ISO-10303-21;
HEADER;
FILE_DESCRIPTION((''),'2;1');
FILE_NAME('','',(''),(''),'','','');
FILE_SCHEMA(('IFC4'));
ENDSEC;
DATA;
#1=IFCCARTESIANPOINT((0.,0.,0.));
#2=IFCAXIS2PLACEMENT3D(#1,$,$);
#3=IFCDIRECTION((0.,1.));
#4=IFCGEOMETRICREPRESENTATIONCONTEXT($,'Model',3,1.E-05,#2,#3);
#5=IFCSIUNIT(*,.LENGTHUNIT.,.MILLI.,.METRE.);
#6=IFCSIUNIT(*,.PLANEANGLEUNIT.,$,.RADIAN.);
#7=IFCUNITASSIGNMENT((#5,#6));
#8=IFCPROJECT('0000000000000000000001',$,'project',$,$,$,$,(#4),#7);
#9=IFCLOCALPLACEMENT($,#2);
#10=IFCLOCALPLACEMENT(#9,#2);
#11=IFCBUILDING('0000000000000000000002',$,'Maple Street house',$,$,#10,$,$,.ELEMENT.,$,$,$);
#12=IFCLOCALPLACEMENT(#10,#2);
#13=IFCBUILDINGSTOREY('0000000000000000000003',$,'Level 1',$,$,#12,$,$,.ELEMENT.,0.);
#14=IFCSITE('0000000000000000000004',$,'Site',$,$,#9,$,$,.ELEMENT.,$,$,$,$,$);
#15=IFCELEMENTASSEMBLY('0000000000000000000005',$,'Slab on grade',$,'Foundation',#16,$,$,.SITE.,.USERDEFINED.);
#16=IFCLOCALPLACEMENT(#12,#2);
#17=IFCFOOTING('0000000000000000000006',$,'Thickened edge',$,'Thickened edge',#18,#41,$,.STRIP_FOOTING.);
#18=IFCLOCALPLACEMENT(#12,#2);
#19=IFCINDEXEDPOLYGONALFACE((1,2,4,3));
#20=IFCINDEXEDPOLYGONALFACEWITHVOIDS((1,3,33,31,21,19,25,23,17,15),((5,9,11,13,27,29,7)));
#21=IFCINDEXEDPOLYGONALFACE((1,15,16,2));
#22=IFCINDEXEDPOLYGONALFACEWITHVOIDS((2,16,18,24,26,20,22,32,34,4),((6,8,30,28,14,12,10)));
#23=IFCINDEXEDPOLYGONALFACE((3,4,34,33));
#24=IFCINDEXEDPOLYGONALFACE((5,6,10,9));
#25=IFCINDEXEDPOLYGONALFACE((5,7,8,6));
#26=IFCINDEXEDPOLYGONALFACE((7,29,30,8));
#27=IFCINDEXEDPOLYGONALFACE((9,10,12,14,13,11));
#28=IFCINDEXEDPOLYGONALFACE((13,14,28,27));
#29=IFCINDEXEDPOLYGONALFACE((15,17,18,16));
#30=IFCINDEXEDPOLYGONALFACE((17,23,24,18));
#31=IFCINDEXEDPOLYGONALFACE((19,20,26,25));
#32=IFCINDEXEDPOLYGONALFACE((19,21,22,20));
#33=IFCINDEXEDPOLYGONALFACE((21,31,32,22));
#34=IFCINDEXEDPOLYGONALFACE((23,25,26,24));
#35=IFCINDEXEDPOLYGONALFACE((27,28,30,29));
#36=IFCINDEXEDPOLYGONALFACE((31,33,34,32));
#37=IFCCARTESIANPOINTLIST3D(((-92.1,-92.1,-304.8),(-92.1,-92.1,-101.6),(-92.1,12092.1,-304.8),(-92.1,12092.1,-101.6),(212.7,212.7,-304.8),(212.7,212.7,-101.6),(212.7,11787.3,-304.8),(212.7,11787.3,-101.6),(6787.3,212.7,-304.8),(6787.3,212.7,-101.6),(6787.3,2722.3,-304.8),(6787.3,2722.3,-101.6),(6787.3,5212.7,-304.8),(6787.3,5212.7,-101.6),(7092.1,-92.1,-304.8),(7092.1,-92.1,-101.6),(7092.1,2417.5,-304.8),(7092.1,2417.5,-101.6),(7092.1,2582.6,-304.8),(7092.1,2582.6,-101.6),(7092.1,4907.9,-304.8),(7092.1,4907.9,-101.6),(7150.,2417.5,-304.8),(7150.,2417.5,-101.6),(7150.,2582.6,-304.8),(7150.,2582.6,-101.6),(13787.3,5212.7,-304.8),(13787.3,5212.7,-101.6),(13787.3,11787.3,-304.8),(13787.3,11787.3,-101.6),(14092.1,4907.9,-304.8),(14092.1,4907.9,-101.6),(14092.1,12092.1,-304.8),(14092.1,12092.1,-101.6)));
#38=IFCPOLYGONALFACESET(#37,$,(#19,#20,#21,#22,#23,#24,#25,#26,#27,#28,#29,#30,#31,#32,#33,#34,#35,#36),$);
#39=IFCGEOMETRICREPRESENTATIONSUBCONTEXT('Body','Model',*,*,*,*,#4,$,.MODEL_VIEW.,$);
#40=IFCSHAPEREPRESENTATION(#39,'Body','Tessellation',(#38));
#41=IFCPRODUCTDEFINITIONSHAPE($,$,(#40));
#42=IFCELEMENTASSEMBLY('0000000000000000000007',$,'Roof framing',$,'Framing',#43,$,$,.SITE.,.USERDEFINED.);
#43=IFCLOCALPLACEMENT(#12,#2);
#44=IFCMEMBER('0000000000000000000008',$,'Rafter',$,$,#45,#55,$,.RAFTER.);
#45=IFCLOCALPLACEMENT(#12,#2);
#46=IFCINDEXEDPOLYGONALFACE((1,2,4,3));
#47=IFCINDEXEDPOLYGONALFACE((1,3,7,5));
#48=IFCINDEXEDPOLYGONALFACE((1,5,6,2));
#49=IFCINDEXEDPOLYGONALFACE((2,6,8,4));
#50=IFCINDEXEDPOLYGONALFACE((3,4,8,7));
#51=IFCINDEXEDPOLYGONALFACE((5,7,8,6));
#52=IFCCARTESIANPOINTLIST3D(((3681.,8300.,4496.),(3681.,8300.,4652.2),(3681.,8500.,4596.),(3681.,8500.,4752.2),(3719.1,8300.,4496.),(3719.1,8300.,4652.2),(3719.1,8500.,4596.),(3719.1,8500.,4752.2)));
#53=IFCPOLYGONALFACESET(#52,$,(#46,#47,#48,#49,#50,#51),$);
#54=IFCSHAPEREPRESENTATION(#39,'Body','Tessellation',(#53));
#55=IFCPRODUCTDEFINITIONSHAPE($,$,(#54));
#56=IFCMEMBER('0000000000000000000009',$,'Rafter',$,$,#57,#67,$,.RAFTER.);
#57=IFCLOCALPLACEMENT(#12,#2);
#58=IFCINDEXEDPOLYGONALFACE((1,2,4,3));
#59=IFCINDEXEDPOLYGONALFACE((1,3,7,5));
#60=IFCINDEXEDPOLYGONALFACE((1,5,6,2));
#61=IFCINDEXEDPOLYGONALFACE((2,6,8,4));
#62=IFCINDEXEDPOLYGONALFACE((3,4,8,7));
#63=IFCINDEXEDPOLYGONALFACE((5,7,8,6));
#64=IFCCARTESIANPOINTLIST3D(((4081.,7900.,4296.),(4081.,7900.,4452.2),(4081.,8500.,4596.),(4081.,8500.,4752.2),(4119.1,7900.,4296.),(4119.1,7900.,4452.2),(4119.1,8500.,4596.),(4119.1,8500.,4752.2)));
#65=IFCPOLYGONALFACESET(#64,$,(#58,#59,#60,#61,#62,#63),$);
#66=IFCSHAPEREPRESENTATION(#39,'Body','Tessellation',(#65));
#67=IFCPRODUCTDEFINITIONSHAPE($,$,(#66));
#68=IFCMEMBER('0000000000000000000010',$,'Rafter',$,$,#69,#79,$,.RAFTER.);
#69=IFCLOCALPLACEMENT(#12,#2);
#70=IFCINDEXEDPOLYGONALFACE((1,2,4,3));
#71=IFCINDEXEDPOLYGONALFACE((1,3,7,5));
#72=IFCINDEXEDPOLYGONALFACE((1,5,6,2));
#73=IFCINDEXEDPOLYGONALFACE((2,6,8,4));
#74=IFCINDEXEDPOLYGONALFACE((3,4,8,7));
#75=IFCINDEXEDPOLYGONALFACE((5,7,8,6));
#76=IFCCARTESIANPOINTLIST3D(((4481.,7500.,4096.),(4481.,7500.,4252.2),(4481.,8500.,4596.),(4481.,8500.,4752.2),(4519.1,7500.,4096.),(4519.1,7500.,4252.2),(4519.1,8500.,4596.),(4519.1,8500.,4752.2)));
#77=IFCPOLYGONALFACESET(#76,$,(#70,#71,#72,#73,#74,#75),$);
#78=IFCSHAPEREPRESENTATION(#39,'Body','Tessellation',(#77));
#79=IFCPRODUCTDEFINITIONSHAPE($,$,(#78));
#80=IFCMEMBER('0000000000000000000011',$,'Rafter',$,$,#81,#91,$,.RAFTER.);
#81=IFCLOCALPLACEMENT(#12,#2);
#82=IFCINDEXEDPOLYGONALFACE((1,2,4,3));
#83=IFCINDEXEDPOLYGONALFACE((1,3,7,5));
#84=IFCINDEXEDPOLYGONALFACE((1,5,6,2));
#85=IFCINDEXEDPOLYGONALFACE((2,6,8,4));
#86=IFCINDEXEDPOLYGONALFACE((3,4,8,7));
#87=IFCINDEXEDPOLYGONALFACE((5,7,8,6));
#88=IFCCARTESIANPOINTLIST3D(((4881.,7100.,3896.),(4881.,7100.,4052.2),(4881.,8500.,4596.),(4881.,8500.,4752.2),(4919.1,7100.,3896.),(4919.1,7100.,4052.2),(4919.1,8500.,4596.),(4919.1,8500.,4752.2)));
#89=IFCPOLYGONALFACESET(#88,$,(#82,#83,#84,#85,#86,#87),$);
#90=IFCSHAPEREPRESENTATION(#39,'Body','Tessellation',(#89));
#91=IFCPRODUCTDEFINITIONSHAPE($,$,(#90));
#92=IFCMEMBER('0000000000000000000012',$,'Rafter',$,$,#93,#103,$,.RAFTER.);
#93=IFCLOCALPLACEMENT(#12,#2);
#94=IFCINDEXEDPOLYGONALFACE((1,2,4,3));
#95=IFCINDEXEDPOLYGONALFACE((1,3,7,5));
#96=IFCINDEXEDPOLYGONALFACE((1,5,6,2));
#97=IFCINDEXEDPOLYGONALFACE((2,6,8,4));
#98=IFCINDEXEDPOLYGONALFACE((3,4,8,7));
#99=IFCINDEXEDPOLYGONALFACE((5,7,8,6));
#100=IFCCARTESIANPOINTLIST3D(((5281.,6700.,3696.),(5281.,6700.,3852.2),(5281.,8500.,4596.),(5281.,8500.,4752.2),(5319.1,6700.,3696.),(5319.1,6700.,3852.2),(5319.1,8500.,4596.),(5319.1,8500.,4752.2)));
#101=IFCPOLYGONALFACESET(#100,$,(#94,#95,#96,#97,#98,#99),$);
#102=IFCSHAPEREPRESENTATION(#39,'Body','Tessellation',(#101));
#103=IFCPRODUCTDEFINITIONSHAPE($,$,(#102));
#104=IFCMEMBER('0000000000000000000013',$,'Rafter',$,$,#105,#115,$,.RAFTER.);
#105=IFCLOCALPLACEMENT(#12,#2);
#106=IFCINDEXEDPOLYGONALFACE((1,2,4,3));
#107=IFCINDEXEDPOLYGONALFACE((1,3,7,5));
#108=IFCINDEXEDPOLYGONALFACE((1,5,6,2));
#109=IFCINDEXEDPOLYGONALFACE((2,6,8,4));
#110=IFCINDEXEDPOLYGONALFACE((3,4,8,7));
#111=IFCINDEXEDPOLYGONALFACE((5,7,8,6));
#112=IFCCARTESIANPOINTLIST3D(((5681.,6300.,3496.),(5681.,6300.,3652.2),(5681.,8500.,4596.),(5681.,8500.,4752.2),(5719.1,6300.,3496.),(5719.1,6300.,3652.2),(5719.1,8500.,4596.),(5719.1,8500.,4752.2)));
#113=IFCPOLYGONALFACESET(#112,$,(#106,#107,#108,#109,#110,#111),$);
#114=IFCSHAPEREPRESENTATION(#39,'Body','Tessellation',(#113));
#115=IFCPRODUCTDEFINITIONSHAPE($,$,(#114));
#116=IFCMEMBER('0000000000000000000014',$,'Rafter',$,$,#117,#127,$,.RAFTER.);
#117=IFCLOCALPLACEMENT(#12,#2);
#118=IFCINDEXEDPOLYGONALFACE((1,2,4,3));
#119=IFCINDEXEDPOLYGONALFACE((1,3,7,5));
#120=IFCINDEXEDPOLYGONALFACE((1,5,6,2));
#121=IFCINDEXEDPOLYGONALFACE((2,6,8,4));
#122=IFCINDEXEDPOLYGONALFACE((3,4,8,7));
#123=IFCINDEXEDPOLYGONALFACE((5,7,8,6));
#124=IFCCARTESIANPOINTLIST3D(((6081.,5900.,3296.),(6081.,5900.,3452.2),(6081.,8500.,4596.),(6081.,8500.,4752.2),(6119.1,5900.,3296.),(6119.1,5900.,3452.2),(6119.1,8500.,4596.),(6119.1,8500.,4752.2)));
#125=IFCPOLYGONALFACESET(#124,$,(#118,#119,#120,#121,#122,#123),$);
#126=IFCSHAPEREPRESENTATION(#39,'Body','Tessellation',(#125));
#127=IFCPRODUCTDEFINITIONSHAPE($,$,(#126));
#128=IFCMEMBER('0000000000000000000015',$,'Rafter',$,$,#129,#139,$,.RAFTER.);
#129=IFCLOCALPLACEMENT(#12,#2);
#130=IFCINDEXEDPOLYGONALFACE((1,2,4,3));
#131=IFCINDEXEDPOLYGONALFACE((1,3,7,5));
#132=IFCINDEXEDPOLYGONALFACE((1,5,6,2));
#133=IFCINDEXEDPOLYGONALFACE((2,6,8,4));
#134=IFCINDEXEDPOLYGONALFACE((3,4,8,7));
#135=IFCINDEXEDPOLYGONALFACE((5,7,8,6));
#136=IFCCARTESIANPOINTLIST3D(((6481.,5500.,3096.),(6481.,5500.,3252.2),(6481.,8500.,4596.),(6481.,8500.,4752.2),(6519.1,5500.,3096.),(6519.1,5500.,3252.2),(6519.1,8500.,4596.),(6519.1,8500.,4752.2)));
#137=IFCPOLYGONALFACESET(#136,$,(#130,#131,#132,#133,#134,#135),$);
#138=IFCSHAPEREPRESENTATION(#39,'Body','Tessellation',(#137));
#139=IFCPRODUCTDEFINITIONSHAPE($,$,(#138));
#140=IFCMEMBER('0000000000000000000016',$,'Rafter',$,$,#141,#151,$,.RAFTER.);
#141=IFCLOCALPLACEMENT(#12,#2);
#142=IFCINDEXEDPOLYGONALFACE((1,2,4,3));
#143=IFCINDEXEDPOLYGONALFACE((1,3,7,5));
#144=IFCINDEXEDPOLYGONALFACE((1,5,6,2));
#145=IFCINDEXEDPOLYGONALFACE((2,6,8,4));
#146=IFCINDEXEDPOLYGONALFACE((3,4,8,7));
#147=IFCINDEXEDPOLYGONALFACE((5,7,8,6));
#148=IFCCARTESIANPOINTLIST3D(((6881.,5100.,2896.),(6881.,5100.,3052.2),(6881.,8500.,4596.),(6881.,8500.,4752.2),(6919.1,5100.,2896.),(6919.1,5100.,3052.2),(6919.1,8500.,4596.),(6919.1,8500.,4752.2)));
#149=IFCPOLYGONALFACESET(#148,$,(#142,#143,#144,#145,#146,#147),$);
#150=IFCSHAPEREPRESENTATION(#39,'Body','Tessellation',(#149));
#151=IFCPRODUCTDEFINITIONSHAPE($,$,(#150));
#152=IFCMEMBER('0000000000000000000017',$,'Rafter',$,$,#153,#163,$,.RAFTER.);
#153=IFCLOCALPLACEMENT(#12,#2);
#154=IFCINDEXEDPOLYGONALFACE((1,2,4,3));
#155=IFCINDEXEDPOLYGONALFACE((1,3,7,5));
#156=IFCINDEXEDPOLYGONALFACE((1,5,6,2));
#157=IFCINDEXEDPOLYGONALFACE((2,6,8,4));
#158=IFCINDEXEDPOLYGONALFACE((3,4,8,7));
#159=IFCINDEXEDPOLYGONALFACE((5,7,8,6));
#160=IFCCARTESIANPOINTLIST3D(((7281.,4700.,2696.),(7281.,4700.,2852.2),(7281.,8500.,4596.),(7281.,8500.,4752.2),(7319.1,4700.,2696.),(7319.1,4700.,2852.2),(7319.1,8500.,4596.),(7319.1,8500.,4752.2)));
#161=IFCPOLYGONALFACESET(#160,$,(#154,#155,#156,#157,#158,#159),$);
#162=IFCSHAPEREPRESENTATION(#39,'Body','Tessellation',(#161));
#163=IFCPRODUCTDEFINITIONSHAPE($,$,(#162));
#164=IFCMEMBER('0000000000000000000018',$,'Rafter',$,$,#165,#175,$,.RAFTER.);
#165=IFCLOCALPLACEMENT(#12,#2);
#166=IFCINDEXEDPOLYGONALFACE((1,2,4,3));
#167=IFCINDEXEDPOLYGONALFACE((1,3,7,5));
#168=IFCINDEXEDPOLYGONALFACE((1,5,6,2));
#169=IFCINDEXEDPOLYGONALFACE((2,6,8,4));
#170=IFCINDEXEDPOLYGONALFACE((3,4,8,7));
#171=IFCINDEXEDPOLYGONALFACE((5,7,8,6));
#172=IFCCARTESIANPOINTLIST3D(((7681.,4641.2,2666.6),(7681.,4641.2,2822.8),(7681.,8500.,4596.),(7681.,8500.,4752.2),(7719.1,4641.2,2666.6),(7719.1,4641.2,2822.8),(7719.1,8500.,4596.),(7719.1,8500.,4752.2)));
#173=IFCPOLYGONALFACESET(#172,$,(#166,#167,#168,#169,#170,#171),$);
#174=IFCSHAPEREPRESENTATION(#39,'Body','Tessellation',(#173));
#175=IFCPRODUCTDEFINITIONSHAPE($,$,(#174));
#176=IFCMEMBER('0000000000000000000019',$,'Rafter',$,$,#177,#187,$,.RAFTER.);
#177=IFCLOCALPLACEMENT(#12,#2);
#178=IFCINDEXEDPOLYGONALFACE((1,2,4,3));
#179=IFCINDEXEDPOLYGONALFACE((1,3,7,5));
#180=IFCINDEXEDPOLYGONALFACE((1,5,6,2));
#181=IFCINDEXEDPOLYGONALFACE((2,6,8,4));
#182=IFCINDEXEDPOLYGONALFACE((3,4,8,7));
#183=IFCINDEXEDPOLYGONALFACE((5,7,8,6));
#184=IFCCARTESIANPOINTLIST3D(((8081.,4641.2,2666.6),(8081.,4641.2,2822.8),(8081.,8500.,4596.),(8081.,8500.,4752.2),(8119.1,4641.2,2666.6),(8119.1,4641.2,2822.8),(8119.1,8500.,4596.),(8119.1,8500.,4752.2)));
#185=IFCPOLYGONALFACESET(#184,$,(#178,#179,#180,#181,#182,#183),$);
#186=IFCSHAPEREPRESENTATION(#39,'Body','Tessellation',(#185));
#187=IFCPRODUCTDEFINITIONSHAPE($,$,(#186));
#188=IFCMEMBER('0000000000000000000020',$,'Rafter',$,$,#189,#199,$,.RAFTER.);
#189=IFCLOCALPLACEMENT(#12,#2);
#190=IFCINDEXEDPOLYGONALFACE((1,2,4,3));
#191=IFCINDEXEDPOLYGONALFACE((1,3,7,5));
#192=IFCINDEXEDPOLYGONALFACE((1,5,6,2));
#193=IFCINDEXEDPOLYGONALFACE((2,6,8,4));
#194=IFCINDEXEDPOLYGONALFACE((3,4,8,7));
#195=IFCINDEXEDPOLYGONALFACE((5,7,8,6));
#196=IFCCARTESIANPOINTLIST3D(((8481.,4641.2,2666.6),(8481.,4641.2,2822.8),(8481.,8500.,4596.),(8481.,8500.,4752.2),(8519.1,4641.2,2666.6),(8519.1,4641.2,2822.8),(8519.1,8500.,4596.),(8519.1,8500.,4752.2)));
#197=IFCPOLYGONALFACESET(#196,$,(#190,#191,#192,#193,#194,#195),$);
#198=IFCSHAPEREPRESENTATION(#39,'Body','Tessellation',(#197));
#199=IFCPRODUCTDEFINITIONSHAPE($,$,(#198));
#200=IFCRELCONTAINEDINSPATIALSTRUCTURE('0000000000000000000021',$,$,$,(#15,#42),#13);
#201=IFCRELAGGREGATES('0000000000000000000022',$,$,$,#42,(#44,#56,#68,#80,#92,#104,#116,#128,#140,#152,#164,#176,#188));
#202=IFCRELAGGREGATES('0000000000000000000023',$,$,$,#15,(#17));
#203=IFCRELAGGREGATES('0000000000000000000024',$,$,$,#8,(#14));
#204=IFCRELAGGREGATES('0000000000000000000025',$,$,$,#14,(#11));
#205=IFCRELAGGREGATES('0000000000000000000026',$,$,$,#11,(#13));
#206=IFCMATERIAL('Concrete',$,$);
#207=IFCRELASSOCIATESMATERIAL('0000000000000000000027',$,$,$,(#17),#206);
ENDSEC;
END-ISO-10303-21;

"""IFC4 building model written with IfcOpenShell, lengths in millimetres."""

from ifc_helpers import new_model, si_unit, direction, frame, origin, origin_with_axes, place, context, subcontext, project, spatial, polyline, outline, extrude, material, element, aggregate, save


model = new_model("IFC4")

# Units and contexts
model_context = context("Model", 3, precision=1e-05, world=origin(), true_north=direction((0.0, 1.0)))
body_context = subcontext(model_context, "Body", "Model", "MODEL_VIEW")
ifc_project = project(units=[si_unit("LENGTHUNIT", "METRE", prefix="MILLI"), si_unit("PLANEANGLEUNIT", "RADIAN")], contexts=[model_context])

# Site, building, storey
site_placement = place(None, origin())
site = spatial("IfcSite", under=ifc_project, at=site_placement, Name="Site", CompositionType="ELEMENT")
building_placement = place(site_placement, origin())
building = spatial("IfcBuilding", under=site, at=building_placement, Name="Maple Street house", CompositionType="ELEMENT")
storey_placement = place(building_placement, origin())
storey = spatial("IfcBuildingStorey", under=building, at=storey_placement, Name="Level 1", CompositionType="ELEMENT", Elevation=0.0)

# Element assembly, footing
assembly_1_placement = place(storey_placement, origin_with_axes())
assembly_1 = element("IfcElementAssembly", 1, at=assembly_1_placement, inside=storey, Name="Slab on grade", ObjectType="Foundation", AssemblyPlace="SITE", PredefinedType="USERDEFINED")
ifc_material = material(Name="Concrete")
footing_placement = place(storey_placement, origin_with_axes())
footing = element("IfcFooting", 2, at=footing_placement, material=ifc_material, Name="Thickened edge", ObjectType="Thickened edge", PredefinedType="STRIP_FOOTING", context=body_context, shape_type="SweptSolid", body=[
    extrude(outline(polyline([(7092.1, 2417.5), (7150.0, 2417.5), (7150.0, 2582.6), (7092.1, 2582.6), (7092.1, 4907.9), (14092.1, 4907.9), (14092.1, 12092.1), (-92.1, 12092.1), (-92.1, -92.1), (7092.1, -92.1), (7092.1, 2417.5)]), holes=[polyline([(6787.3, 2722.3), (6845.2, 2722.3), (6845.2, 2277.8), (6787.3, 2277.8), (6787.3, 5212.7), (13787.3, 5212.7), (13787.3, 11787.3), (212.7, 11787.3), (212.7, 212.7), (6787.3, 212.7), (6787.3, 2722.3)])]), frame((0.0, 0.0, -304.8)), (0.0, 0.0, 1.0), 203.2),
])

# Element assembly, members
assembly_2_placement = place(storey_placement, origin_with_axes())
assembly_2 = element("IfcElementAssembly", 3, at=assembly_2_placement, inside=storey, Name="Roof framing", ObjectType="Framing", AssemblyPlace="SITE", PredefinedType="USERDEFINED")
member_1_placement = place(storey_placement, origin_with_axes())
member_1 = element("IfcMember", 4, at=member_1_placement, Name="Rafter", PredefinedType="RAFTER", context=body_context, shape_type="SweptSolid", body=[
    extrude(outline(polyline([(0.0, 0.0), (38.1, 0.0), (38.1, 156.2), (0.0, 156.2), (0.0, 0.0)])), frame((3719.1, 8300.0, 4496.0), z_axis=(0.0, 1.0, 0.0), x_axis=(-1.0, 0.0, 0.0)), (0.0, 0.447214, 0.894427), 223.6),
])
member_2_placement = place(storey_placement, origin_with_axes())
member_2 = element("IfcMember", 5, at=member_2_placement, Name="Rafter", PredefinedType="RAFTER", context=body_context, shape_type="SweptSolid", body=[
    extrude(outline(polyline([(0.0, 0.0), (38.1, 0.0), (38.1, 156.2), (0.0, 156.2), (0.0, 0.0)])), frame((4119.1, 7900.0, 4296.0), z_axis=(0.0, 1.0, 0.0), x_axis=(-1.0, 0.0, 0.0)), (0.0, 0.447214, 0.894427), 670.8),
])
member_3_placement = place(storey_placement, origin_with_axes())
member_3 = element("IfcMember", 6, at=member_3_placement, Name="Rafter", PredefinedType="RAFTER", context=body_context, shape_type="SweptSolid", body=[
    extrude(outline(polyline([(0.0, 0.0), (38.1, 0.0), (38.1, 156.2), (0.0, 156.2), (0.0, 0.0)])), frame((4519.1, 7500.0, 4096.0), z_axis=(0.0, 1.0, 0.0), x_axis=(-1.0, 0.0, 0.0)), (0.0, 0.447214, 0.894427), 1118.0),
])
member_4_placement = place(storey_placement, origin_with_axes())
member_4 = element("IfcMember", 7, at=member_4_placement, Name="Rafter", PredefinedType="RAFTER", context=body_context, shape_type="SweptSolid", body=[
    extrude(outline(polyline([(0.0, 0.0), (38.1, 0.0), (38.1, 156.2), (0.0, 156.2), (0.0, 0.0)])), frame((4919.1, 7100.0, 3896.0), z_axis=(0.0, 1.0, 0.0), x_axis=(-1.0, 0.0, 0.0)), (0.0, 0.447214, 0.894427), 1565.2),
])
member_5_placement = place(storey_placement, origin_with_axes())
member_5 = element("IfcMember", 8, at=member_5_placement, Name="Rafter", PredefinedType="RAFTER", context=body_context, shape_type="SweptSolid", body=[
    extrude(outline(polyline([(0.0, 0.0), (38.1, 0.0), (38.1, 156.2), (0.0, 156.2), (0.0, 0.0)])), frame((5319.1, 6700.0, 3696.0), z_axis=(0.0, 1.0, 0.0), x_axis=(-1.0, 0.0, 0.0)), (0.0, 0.447214, 0.894427), 2012.5),
])
member_6_placement = place(storey_placement, origin_with_axes())
member_6 = element("IfcMember", 9, at=member_6_placement, Name="Rafter", PredefinedType="RAFTER", context=body_context, shape_type="SweptSolid", body=[
    extrude(outline(polyline([(0.0, 0.0), (38.1, 0.0), (38.1, 156.2), (0.0, 156.2), (0.0, 0.0)])), frame((5719.1, 6300.0, 3496.0), z_axis=(0.0, 1.0, 0.0), x_axis=(-1.0, 0.0, 0.0)), (0.0, 0.447214, 0.894427), 2459.7),
])
member_7_placement = place(storey_placement, origin_with_axes())
member_7 = element("IfcMember", 10, at=member_7_placement, Name="Rafter", PredefinedType="RAFTER", context=body_context, shape_type="SweptSolid", body=[
    extrude(outline(polyline([(0.0, 0.0), (38.1, 0.0), (38.1, 156.2), (0.0, 156.2), (0.0, 0.0)])), frame((6119.1, 5900.0, 3296.0), z_axis=(0.0, 1.0, 0.0), x_axis=(-1.0, 0.0, 0.0)), (0.0, 0.447214, 0.894427), 2906.9),
])
member_8_placement = place(storey_placement, origin_with_axes())
member_8 = element("IfcMember", 11, at=member_8_placement, Name="Rafter", PredefinedType="RAFTER", context=body_context, shape_type="SweptSolid", body=[
    extrude(outline(polyline([(0.0, 0.0), (38.1, 0.0), (38.1, 156.2), (0.0, 156.2), (0.0, 0.0)])), frame((6519.1, 5500.0, 3096.0), z_axis=(0.0, 1.0, 0.0), x_axis=(-1.0, 0.0, 0.0)), (0.0, 0.447214, 0.894427), 3354.1),
])
member_9_placement = place(storey_placement, origin_with_axes())
member_9 = element("IfcMember", 12, at=member_9_placement, Name="Rafter", PredefinedType="RAFTER", context=body_context, shape_type="SweptSolid", body=[
    extrude(outline(polyline([(0.0, 0.0), (38.1, 0.0), (38.1, 156.2), (0.0, 156.2), (0.0, 0.0)])), frame((6919.1, 5100.0, 2896.0), z_axis=(0.0, 1.0, 0.0), x_axis=(-1.0, 0.0, 0.0)), (0.0, 0.447214, 0.894427), 3801.3),
])
member_10_placement = place(storey_placement, origin_with_axes())
member_10 = element("IfcMember", 13, at=member_10_placement, Name="Rafter", PredefinedType="RAFTER", context=body_context, shape_type="SweptSolid", body=[
    extrude(outline(polyline([(0.0, 0.0), (38.1, 0.0), (38.1, 156.2), (0.0, 156.2), (0.0, 0.0)])), frame((7319.1, 4700.0, 2696.0), z_axis=(0.0, 1.0, 0.0), x_axis=(-1.0, 0.0, 0.0)), (0.0, 0.447214, 0.894427), 4248.5),
])
member_11_placement = place(storey_placement, origin_with_axes())
member_11 = element("IfcMember", 14, at=member_11_placement, Name="Rafter", PredefinedType="RAFTER", context=body_context, shape_type="SweptSolid", body=[
    extrude(outline(polyline([(0.0, 0.0), (38.1, 0.0), (38.1, 156.2), (0.0, 156.2), (0.0, 0.0)])), frame((7719.1, 4641.2, 2666.7), z_axis=(0.0, 1.0, 0.0), x_axis=(-1.0, 0.0, 0.0)), (0.0, 0.447214, 0.894427), 4314.2),
])
member_12_placement = place(storey_placement, origin_with_axes())
member_12 = element("IfcMember", 15, at=member_12_placement, Name="Rafter", PredefinedType="RAFTER", context=body_context, shape_type="SweptSolid", body=[
    extrude(outline(polyline([(0.0, 0.0), (38.1, 0.0), (38.1, 156.2), (0.0, 156.2), (0.0, 0.0)])), frame((8119.1, 4641.2, 2666.7), z_axis=(0.0, 1.0, 0.0), x_axis=(-1.0, 0.0, 0.0)), (0.0, 0.447214, 0.894427), 4314.2),
])
member_13_placement = place(storey_placement, origin_with_axes())
member_13 = element("IfcMember", 16, at=member_13_placement, Name="Rafter", PredefinedType="RAFTER", context=body_context, shape_type="SweptSolid", body=[
    extrude(outline(polyline([(0.0, 0.0), (38.1, 0.0), (38.1, 156.2), (0.0, 156.2), (0.0, 0.0)])), frame((8519.1, 4641.2, 2666.7), z_axis=(0.0, 1.0, 0.0), x_axis=(-1.0, 0.0, 0.0)), (0.0, 0.447214, 0.894427), 4314.2),
])
aggregate(assembly_2, [member_1, member_2, member_3, member_4, member_5, member_6, member_7, member_8, member_9, member_10, member_11, member_12, member_13])

aggregate(assembly_1, [footing])

save(model, "model.ifc")
